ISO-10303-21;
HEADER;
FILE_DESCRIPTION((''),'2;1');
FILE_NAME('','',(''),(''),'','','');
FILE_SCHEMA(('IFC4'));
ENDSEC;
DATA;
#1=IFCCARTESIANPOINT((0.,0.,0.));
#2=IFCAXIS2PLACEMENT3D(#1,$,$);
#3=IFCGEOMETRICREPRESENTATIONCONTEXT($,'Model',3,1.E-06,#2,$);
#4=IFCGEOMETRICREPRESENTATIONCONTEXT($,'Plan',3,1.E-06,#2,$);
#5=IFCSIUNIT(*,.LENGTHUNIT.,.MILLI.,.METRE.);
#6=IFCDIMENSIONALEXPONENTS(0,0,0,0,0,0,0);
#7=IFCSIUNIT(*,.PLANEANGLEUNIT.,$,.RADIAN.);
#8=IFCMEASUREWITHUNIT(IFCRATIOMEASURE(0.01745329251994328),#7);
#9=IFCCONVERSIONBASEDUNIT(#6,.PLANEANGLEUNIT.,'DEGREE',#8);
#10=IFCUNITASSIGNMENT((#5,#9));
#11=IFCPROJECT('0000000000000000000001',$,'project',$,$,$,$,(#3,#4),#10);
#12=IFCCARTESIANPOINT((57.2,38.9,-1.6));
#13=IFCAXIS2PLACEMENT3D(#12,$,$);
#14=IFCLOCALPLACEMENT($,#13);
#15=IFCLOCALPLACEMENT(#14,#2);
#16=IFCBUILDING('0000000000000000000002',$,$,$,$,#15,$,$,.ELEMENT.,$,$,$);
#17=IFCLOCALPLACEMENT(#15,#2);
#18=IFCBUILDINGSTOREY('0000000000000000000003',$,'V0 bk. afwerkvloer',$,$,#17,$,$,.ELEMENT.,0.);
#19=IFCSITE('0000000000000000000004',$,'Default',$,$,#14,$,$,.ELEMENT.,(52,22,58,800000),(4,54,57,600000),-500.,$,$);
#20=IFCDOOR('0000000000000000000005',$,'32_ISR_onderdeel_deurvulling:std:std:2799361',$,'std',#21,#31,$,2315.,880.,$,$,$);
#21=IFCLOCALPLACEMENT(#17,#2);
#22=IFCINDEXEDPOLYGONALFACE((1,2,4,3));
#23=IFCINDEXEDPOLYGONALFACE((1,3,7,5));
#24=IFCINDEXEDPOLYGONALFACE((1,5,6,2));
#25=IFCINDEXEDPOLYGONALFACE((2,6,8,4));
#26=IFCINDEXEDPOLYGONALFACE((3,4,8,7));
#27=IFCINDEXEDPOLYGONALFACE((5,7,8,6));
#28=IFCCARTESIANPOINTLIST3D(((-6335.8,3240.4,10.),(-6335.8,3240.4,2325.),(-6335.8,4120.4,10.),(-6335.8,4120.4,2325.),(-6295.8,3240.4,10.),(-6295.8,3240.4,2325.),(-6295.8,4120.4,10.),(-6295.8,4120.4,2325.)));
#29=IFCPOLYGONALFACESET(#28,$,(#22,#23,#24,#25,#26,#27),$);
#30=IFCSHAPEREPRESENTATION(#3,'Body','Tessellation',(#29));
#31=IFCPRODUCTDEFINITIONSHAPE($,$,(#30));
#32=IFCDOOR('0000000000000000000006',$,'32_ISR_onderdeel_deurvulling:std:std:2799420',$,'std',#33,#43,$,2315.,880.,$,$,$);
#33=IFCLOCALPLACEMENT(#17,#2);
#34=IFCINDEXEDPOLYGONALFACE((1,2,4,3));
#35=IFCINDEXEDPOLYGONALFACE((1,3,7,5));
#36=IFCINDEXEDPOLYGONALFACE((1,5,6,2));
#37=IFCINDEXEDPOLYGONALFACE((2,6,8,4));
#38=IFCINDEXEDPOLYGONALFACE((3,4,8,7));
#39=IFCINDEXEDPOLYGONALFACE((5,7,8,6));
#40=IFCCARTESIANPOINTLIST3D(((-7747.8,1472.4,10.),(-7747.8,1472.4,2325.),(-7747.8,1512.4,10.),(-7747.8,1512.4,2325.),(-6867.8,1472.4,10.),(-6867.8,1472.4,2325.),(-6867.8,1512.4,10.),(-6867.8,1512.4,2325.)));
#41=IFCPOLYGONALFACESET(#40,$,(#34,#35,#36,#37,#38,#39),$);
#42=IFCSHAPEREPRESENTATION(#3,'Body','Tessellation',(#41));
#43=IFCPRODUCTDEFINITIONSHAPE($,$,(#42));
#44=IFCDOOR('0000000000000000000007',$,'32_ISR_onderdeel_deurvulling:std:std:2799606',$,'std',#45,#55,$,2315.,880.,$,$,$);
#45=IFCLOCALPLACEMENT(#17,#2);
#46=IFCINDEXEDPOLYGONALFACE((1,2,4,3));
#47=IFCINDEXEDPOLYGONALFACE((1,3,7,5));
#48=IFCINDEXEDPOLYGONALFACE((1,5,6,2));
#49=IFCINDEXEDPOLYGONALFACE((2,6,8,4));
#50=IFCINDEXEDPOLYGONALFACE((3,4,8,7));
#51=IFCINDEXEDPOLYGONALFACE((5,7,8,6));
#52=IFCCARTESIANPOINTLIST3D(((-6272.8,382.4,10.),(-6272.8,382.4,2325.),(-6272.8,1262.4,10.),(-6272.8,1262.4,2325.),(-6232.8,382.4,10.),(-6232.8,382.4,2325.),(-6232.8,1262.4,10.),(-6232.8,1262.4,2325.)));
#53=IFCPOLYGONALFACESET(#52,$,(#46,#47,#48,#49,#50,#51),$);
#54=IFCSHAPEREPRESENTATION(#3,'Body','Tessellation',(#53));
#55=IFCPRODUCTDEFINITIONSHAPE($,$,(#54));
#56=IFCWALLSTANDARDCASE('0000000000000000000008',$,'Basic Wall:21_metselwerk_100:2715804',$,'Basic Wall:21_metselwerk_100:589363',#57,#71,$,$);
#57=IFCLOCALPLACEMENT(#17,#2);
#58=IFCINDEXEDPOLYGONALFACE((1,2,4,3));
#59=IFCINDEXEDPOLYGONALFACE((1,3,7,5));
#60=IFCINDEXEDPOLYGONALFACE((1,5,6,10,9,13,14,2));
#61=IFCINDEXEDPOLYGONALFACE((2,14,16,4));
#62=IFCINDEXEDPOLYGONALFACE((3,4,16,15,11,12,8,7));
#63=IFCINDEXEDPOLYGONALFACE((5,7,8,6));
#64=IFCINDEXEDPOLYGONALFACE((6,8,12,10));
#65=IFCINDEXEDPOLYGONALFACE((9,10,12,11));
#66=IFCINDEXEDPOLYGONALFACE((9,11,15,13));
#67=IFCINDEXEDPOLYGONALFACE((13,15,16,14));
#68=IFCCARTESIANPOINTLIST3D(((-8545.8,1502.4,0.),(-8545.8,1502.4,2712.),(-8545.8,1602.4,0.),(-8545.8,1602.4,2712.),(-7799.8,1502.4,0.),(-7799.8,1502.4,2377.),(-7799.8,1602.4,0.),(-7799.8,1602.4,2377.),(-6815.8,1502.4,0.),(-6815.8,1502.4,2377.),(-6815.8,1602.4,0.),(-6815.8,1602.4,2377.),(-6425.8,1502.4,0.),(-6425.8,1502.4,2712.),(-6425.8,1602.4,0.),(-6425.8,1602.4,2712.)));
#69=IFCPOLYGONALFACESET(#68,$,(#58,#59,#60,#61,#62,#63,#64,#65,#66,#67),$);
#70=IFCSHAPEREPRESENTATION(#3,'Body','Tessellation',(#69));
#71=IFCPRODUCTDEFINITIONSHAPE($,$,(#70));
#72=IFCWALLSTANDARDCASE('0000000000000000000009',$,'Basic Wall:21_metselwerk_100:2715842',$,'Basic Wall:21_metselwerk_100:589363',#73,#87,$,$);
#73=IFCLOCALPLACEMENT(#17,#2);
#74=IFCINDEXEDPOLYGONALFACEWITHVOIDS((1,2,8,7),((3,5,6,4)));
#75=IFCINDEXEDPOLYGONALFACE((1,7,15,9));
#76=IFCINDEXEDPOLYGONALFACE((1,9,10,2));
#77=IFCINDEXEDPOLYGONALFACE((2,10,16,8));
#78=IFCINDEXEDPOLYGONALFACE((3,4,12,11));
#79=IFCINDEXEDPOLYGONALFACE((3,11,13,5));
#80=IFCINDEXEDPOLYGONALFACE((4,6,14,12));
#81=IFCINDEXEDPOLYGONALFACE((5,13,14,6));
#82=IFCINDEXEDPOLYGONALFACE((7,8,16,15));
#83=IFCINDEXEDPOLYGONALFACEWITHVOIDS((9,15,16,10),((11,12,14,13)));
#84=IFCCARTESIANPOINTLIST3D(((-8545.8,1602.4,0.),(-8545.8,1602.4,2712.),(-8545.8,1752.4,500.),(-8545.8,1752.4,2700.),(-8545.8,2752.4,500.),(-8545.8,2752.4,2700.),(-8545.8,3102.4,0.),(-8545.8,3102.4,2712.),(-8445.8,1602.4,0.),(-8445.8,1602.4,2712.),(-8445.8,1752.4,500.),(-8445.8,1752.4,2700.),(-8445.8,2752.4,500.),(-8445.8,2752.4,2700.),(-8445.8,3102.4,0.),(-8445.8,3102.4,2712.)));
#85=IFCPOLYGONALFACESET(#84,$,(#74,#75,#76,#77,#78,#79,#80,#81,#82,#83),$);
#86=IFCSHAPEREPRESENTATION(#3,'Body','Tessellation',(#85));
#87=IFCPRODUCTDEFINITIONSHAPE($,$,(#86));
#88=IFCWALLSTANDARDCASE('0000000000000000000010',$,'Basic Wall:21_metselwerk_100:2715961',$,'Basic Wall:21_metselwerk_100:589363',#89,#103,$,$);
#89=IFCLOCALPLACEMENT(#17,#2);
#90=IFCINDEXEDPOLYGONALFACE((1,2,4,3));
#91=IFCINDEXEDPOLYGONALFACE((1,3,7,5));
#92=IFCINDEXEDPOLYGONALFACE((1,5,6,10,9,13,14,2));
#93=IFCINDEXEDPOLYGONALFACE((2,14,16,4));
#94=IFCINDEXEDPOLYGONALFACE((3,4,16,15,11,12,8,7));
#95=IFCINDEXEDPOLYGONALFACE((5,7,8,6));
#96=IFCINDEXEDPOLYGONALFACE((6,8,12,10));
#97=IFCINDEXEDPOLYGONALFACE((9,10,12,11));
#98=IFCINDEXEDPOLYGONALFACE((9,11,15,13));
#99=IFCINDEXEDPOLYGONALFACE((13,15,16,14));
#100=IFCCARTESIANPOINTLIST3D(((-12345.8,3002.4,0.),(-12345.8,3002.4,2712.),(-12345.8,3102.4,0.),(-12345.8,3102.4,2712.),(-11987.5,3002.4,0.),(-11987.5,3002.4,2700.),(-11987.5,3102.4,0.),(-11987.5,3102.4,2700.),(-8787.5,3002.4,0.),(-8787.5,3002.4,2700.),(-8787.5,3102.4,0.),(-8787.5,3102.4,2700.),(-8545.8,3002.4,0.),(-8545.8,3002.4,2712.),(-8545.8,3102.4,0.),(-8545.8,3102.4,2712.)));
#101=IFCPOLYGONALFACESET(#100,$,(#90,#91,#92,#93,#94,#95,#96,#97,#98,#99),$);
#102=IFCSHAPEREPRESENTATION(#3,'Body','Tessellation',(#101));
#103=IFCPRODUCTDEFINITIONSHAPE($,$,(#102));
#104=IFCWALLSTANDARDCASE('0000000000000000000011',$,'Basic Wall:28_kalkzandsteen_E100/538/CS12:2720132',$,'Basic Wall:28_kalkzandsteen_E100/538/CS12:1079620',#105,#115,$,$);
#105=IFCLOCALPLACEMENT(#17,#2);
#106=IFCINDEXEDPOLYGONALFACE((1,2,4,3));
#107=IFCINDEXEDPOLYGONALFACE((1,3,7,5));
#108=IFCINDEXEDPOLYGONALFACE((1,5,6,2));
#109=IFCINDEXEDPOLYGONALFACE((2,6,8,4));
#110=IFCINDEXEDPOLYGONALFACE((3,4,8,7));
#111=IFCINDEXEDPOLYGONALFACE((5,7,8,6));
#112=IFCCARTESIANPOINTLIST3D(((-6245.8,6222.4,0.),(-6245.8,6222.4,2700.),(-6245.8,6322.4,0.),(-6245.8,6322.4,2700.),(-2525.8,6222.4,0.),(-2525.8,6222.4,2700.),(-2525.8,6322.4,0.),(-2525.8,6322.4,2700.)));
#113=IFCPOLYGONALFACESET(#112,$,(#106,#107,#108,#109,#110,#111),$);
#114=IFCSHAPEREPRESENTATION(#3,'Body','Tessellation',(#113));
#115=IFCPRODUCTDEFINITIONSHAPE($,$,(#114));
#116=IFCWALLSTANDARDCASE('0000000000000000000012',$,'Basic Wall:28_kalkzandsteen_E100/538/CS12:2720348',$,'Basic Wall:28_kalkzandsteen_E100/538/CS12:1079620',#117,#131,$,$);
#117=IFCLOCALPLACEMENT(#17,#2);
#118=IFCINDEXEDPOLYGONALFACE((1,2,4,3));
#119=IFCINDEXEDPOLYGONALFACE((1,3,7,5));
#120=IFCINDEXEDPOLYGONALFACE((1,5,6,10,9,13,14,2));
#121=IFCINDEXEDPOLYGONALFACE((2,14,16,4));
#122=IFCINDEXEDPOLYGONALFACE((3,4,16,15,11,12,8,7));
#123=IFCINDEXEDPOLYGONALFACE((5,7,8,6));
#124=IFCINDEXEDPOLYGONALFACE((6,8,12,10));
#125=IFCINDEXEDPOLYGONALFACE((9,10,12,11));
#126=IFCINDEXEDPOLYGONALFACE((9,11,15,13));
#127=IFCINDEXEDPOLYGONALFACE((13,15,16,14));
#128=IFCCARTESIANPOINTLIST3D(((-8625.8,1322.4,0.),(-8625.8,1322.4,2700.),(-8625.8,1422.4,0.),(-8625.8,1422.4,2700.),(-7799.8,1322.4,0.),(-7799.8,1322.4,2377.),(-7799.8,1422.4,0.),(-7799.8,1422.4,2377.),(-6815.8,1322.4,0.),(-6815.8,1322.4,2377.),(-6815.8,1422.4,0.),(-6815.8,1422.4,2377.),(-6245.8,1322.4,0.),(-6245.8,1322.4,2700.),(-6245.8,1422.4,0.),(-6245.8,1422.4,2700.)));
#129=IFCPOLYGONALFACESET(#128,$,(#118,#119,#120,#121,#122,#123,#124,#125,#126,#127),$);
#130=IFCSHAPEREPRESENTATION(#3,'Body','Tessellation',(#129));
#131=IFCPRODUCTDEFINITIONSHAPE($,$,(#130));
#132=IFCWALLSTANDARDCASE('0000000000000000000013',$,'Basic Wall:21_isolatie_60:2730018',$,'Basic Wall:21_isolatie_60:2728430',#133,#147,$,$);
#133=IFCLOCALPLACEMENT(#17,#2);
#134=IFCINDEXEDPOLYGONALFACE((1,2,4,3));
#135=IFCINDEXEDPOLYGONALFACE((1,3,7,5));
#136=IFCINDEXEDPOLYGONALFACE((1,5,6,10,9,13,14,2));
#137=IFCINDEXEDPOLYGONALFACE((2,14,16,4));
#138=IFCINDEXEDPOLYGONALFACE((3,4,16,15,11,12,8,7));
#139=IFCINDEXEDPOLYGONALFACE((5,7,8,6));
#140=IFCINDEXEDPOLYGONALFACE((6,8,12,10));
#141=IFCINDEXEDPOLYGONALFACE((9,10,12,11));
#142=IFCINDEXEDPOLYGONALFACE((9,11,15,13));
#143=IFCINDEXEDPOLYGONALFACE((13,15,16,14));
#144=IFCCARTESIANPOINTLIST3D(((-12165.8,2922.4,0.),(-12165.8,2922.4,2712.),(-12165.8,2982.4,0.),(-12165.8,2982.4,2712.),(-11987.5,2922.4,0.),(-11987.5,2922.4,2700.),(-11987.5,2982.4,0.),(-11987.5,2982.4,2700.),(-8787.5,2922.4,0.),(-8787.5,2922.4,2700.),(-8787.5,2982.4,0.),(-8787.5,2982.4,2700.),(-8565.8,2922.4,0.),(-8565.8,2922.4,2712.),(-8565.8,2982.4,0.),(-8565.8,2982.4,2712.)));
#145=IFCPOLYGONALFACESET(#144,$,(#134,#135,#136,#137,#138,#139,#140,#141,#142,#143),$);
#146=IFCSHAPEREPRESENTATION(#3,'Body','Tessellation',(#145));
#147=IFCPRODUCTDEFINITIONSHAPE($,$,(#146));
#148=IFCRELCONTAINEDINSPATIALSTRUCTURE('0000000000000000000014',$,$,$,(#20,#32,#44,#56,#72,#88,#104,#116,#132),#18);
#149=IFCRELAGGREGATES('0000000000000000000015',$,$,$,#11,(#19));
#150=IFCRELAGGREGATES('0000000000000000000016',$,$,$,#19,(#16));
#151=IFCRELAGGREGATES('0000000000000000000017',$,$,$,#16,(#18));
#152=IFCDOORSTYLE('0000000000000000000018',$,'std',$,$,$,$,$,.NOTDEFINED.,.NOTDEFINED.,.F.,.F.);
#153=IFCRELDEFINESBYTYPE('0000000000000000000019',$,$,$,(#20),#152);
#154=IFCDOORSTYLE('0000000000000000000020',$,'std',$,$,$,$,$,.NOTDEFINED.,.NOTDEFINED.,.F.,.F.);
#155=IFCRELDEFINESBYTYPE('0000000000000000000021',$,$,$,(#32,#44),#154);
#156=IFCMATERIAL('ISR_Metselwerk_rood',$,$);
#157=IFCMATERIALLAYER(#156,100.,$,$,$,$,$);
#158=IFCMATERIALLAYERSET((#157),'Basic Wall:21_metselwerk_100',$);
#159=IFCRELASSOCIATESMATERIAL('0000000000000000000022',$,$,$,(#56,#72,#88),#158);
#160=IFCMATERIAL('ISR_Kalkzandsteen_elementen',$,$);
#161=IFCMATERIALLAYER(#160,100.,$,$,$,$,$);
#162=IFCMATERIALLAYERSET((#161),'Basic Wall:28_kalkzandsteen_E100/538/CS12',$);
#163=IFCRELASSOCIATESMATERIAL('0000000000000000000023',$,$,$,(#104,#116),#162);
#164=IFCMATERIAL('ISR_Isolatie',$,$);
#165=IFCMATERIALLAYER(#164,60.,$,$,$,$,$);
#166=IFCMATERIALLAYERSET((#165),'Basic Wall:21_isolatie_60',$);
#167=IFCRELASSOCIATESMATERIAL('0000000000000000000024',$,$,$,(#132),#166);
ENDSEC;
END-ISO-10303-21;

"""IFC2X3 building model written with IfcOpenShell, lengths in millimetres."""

from ifc_helpers import new_model, entity, si_unit, converted_unit, frame, frame_2d, origin, origin_2d_with_axis, place, context, project, spatial, rectangle, extrude, source, transform, mapped, material, layer, layer_set, layer_usage, type_object, type_shapes, element, save


model = new_model("IFC2X3")

# Units and contexts
model_context = context("Model", 3, precision=1e-06, world=origin())
plan_context = context("Plan", 3, precision=1e-06, world=origin())
ifc_project = project(units=[si_unit("LENGTHUNIT", "METRE", prefix="MILLI"), converted_unit("PLANEANGLEUNIT", "DEGREE", entity("IfcRatioMeasure", 0.01745329251994328), si_unit("PLANEANGLEUNIT", "RADIAN"), dimensions=[0, 0, 0, 0, 0, 0, 0])], contexts=[model_context, plan_context])

# Site, building, storey
site_placement = place(None, frame((57.2, 38.9, -1.6)))
site = spatial("IfcSite", under=ifc_project, at=site_placement, Name="Default", CompositionType="ELEMENT", RefLatitude=(52, 22, 58, 800000), RefLongitude=(4, 54, 57, 600000), RefElevation=-500.0)
building_placement = place(site_placement, origin())
building = spatial("IfcBuilding", under=site, at=building_placement, CompositionType="ELEMENT")
storey_placement = place(building_placement, origin())
storey = spatial("IfcBuildingStorey", under=building, at=storey_placement, Name="V0 bk. afwerkvloer", CompositionType="ELEMENT", Elevation=0.0)

# Doors
door_style_1 = type_object("IfcDoorStyle", Name="std", ConstructionType="NOTDEFINED", OperationType="NOTDEFINED", ParameterTakesPrecedence=False, Sizeable=False)
shared_shape_1 = source(origin(), model_context, "Body", "SweptSolid", [
    extrude(rectangle(XDim=880.0, YDim=40.0, at=origin_2d_with_axis()), frame((0.0, 34.0, 0.0)), (0.0, 0.0, 1.0), 2315.0),
])
type_shapes(door_style_1, [shared_shape_1])
door_1_placement = place(storey_placement, frame((-6349.8, 3680.4, 10.0), z_axis=(0.0, 0.0, 1.0), x_axis=(0.0, -1.0, 0.0)))
element("IfcDoor", 1, at=door_1_placement, inside=storey, type_object=door_style_1, Name="32_ISR_onderdeel_deurvulling:std:std:2799361", ObjectType="std", OverallHeight=2315.0, OverallWidth=880.0, context=model_context, shape_type="MappedRepresentation", body=[
    mapped(shared_shape_1, transform((0.0, 0.0, 0.0), scale=1.0)),
])
door_style_2 = type_object("IfcDoorStyle", Name="std", ConstructionType="NOTDEFINED", OperationType="NOTDEFINED", ParameterTakesPrecedence=False, Sizeable=False)
shared_shape_2 = source(origin(), model_context, "Body", "SweptSolid", [
    extrude(rectangle(XDim=40.0, YDim=880.0, at=origin_2d_with_axis()), frame((0.0, -34.0, 0.0), z_axis=(0.0, 0.0, 1.0), x_axis=(0.0, -1.0, 0.0)), (0.0, 0.0, 1.0), 2315.0),
])
type_shapes(door_style_2, [shared_shape_2])
door_2_placement = place(storey_placement, frame((-7307.8, 1526.4, 10.0)))
element("IfcDoor", 2, at=door_2_placement, inside=storey, type_object=door_style_2, Name="32_ISR_onderdeel_deurvulling:std:std:2799420", ObjectType="std", OverallHeight=2315.0, OverallWidth=880.0, context=model_context, shape_type="MappedRepresentation", body=[
    mapped(shared_shape_2, transform((0.0, 0.0, 0.0), scale=1.0)),
])
door_3_placement = place(storey_placement, frame((-6218.8, 822.4, 10.0), z_axis=(0.0, 0.0, 1.0), x_axis=(0.0, -1.0, 0.0)))
element("IfcDoor", 3, at=door_3_placement, inside=storey, type_object=door_style_2, Name="32_ISR_onderdeel_deurvulling:std:std:2799606", ObjectType="std", OverallHeight=2315.0, OverallWidth=880.0, context=model_context, shape_type="MappedRepresentation", body=[
    mapped(shared_shape_2, transform((0.0, 0.0, 0.0), scale=1.0)),
])

# Walls, openings
ifc_material_1 = material(Name="ISR_Metselwerk_rood")
ifc_layer_1 = layer(ifc_material_1, 100.0)
ifc_layer_set_1 = layer_set([ifc_layer_1], Name="Basic Wall:21_metselwerk_100")
ifc_layer_usage_1 = layer_usage(ifc_layer_set_1, "AXIS2", "NEGATIVE", 50.0)
wall_1_placement = place(storey_placement, frame((-6425.8, 1552.4, 0.0), z_axis=(0.0, 0.0, 1.0), x_axis=(-1.0, 0.0, 0.0)))
wall_1 = element("IfcWallStandardCase", 4, at=wall_1_placement, inside=storey, material=ifc_layer_usage_1, Name="Basic Wall:21_metselwerk_100:2715804", ObjectType="Basic Wall:21_metselwerk_100:589363", context=model_context, shape_type="SweptSolid", body=[
    extrude(rectangle(XDim=2120.0, YDim=100.0, at=frame_2d((1060.0, 0.0), x_axis=(-1.0, 0.0))), origin(), (0.0, 0.0, 1.0), 2712.0),
])
opening_1_placement = place(wall_1_placement, origin())
element("IfcOpeningElement", 5, at=opening_1_placement, cuts=wall_1, ObjectType="Opening", context=model_context, shape_type="SweptSolid", body=[
    extrude(rectangle(XDim=2377.0, YDim=984.0, at=origin_2d_with_axis()), frame((882.0, -1394.0, 1188.5), z_axis=(0.0, 1.0, 0.0), x_axis=(0.0, 0.0, 1.0)), (0.0, 0.0, 1.0), 3048.0),
])
ifc_layer_usage_2 = layer_usage(ifc_layer_set_1, "AXIS2", "NEGATIVE", 50.0)
wall_2_placement = place(storey_placement, frame((-8495.8, 1602.4, 0.0), z_axis=(0.0, 0.0, 1.0), x_axis=(0.0, 1.0, 0.0)))
wall_2 = element("IfcWallStandardCase", 6, at=wall_2_placement, inside=storey, material=ifc_layer_usage_2, Name="Basic Wall:21_metselwerk_100:2715842", ObjectType="Basic Wall:21_metselwerk_100:589363", context=model_context, shape_type="SweptSolid", body=[
    extrude(rectangle(XDim=1500.0, YDim=100.0, at=frame_2d((750.0, 0.0), x_axis=(-1.0, 0.0))), origin(), (0.0, 0.0, 1.0), 2712.0),
])
opening_2_placement = place(wall_2_placement, origin())
element("IfcOpeningElement", 7, at=opening_2_placement, cuts=wall_2, ObjectType="Opening", context=model_context, shape_type="SweptSolid", body=[
    extrude(rectangle(XDim=2200.0, YDim=1000.0, at=frame_2d((0.0, 0.0), x_axis=(0.0, 1.0))), frame((650.0, -202.4, 1600.0), z_axis=(0.0, 1.0, 0.0), x_axis=(-1.0, 0.0, 0.0)), (0.0, 0.0, 1.0), 404.8),
])
ifc_layer_usage_3 = layer_usage(ifc_layer_set_1, "AXIS2", "NEGATIVE", 50.0)
wall_3_placement = place(storey_placement, frame((-8545.8, 3052.4, 0.0), z_axis=(0.0, 0.0, 1.0), x_axis=(-1.0, 0.0, 0.0)))
wall_3 = element("IfcWallStandardCase", 8, at=wall_3_placement, inside=storey, material=ifc_layer_usage_3, Name="Basic Wall:21_metselwerk_100:2715961", ObjectType="Basic Wall:21_metselwerk_100:589363", context=model_context, shape_type="SweptSolid", body=[
    extrude(rectangle(XDim=3800.0, YDim=100.0, at=frame_2d((1900.0, 0.0), x_axis=(-1.0, 0.0))), origin(), (0.0, 0.0, 1.0), 2712.0),
])
opening_3_placement = place(wall_3_placement, origin())
element("IfcOpeningElement", 9, at=opening_3_placement, cuts=wall_3, ObjectType="Opening", context=model_context, shape_type="SweptSolid", body=[
    extrude(rectangle(XDim=2700.0, YDim=3200.0, at=origin_2d_with_axis()), frame((1841.7, -202.4, 1350.0), z_axis=(0.0, 1.0, 0.0), x_axis=(0.0, 0.0, 1.0)), (0.0, 0.0, 1.0), 404.8),
])

# Wall
ifc_material_2 = material(Name="ISR_Kalkzandsteen_elementen")
ifc_layer_2 = layer(ifc_material_2, 100.0)
ifc_layer_set_2 = layer_set([ifc_layer_2], Name="Basic Wall:28_kalkzandsteen_E100/538/CS12")
ifc_layer_usage_4 = layer_usage(ifc_layer_set_2, "AXIS2", "NEGATIVE", 50.0)
wall_4_placement = place(storey_placement, frame((-2525.8, 6272.4, 0.0), z_axis=(0.0, 0.0, 1.0), x_axis=(-1.0, 0.0, 0.0)))
element("IfcWallStandardCase", 10, at=wall_4_placement, inside=storey, material=ifc_layer_usage_4, Name="Basic Wall:28_kalkzandsteen_E100/538/CS12:2720132", ObjectType="Basic Wall:28_kalkzandsteen_E100/538/CS12:1079620", context=model_context, shape_type="SweptSolid", body=[
    extrude(rectangle(XDim=3720.0, YDim=100.0, at=frame_2d((1860.0, 0.0), x_axis=(-1.0, 0.0))), origin(), (0.0, 0.0, 1.0), 2700.0),
])

# Walls, openings
ifc_layer_usage_5 = layer_usage(ifc_layer_set_2, "AXIS2", "NEGATIVE", 50.0)
wall_5_placement = place(storey_placement, frame((-6245.8, 1372.4, 0.0), z_axis=(0.0, 0.0, 1.0), x_axis=(-1.0, 0.0, 0.0)))
wall_5 = element("IfcWallStandardCase", 11, at=wall_5_placement, inside=storey, material=ifc_layer_usage_5, Name="Basic Wall:28_kalkzandsteen_E100/538/CS12:2720348", ObjectType="Basic Wall:28_kalkzandsteen_E100/538/CS12:1079620", context=model_context, shape_type="SweptSolid", body=[
    extrude(rectangle(XDim=2380.0, YDim=100.0, at=frame_2d((1190.0, 0.0), x_axis=(-1.0, 0.0))), origin(), (0.0, 0.0, 1.0), 2700.0),
])
opening_4_placement = place(wall_5_placement, origin())
element("IfcOpeningElement", 12, at=opening_4_placement, cuts=wall_5, ObjectType="Opening", context=model_context, shape_type="SweptSolid", body=[
    extrude(rectangle(XDim=2377.0, YDim=984.0, at=origin_2d_with_axis()), frame((1062.0, -1574.0, 1188.5), z_axis=(0.0, 1.0, 0.0), x_axis=(0.0, 0.0, 1.0)), (0.0, 0.0, 1.0), 3048.0),
])
ifc_material_3 = material(Name="ISR_Isolatie")
ifc_layer_3 = layer(ifc_material_3, 60.0)
ifc_layer_set_3 = layer_set([ifc_layer_3], Name="Basic Wall:21_isolatie_60")
ifc_layer_usage_6 = layer_usage(ifc_layer_set_3, "AXIS2", "NEGATIVE", 30.0)
wall_6_placement = place(storey_placement, frame((-8565.8, 2952.4, 0.0), z_axis=(0.0, 0.0, 1.0), x_axis=(-1.0, 0.0, 0.0)))
wall_6 = element("IfcWallStandardCase", 13, at=wall_6_placement, inside=storey, material=ifc_layer_usage_6, Name="Basic Wall:21_isolatie_60:2730018", ObjectType="Basic Wall:21_isolatie_60:2728430", context=model_context, shape_type="SweptSolid", body=[
    extrude(rectangle(XDim=3600.0, YDim=60.0, at=frame_2d((1800.0, 0.0), x_axis=(-1.0, 0.0))), origin(), (0.0, 0.0, 1.0), 2712.0),
])
opening_5_placement = place(wall_6_placement, origin())
element("IfcOpeningElement", 14, at=opening_5_placement, cuts=wall_6, ObjectType="Opening", context=model_context, shape_type="SweptSolid", body=[
    extrude(rectangle(XDim=2700.0, YDim=3200.0, at=origin_2d_with_axis()), frame((1821.7, -182.4, 1350.0), z_axis=(0.0, 1.0, 0.0), x_axis=(0.0, 0.0, 1.0)), (0.0, 0.0, 1.0), 364.8),
])

save(model, "model.ifc")
